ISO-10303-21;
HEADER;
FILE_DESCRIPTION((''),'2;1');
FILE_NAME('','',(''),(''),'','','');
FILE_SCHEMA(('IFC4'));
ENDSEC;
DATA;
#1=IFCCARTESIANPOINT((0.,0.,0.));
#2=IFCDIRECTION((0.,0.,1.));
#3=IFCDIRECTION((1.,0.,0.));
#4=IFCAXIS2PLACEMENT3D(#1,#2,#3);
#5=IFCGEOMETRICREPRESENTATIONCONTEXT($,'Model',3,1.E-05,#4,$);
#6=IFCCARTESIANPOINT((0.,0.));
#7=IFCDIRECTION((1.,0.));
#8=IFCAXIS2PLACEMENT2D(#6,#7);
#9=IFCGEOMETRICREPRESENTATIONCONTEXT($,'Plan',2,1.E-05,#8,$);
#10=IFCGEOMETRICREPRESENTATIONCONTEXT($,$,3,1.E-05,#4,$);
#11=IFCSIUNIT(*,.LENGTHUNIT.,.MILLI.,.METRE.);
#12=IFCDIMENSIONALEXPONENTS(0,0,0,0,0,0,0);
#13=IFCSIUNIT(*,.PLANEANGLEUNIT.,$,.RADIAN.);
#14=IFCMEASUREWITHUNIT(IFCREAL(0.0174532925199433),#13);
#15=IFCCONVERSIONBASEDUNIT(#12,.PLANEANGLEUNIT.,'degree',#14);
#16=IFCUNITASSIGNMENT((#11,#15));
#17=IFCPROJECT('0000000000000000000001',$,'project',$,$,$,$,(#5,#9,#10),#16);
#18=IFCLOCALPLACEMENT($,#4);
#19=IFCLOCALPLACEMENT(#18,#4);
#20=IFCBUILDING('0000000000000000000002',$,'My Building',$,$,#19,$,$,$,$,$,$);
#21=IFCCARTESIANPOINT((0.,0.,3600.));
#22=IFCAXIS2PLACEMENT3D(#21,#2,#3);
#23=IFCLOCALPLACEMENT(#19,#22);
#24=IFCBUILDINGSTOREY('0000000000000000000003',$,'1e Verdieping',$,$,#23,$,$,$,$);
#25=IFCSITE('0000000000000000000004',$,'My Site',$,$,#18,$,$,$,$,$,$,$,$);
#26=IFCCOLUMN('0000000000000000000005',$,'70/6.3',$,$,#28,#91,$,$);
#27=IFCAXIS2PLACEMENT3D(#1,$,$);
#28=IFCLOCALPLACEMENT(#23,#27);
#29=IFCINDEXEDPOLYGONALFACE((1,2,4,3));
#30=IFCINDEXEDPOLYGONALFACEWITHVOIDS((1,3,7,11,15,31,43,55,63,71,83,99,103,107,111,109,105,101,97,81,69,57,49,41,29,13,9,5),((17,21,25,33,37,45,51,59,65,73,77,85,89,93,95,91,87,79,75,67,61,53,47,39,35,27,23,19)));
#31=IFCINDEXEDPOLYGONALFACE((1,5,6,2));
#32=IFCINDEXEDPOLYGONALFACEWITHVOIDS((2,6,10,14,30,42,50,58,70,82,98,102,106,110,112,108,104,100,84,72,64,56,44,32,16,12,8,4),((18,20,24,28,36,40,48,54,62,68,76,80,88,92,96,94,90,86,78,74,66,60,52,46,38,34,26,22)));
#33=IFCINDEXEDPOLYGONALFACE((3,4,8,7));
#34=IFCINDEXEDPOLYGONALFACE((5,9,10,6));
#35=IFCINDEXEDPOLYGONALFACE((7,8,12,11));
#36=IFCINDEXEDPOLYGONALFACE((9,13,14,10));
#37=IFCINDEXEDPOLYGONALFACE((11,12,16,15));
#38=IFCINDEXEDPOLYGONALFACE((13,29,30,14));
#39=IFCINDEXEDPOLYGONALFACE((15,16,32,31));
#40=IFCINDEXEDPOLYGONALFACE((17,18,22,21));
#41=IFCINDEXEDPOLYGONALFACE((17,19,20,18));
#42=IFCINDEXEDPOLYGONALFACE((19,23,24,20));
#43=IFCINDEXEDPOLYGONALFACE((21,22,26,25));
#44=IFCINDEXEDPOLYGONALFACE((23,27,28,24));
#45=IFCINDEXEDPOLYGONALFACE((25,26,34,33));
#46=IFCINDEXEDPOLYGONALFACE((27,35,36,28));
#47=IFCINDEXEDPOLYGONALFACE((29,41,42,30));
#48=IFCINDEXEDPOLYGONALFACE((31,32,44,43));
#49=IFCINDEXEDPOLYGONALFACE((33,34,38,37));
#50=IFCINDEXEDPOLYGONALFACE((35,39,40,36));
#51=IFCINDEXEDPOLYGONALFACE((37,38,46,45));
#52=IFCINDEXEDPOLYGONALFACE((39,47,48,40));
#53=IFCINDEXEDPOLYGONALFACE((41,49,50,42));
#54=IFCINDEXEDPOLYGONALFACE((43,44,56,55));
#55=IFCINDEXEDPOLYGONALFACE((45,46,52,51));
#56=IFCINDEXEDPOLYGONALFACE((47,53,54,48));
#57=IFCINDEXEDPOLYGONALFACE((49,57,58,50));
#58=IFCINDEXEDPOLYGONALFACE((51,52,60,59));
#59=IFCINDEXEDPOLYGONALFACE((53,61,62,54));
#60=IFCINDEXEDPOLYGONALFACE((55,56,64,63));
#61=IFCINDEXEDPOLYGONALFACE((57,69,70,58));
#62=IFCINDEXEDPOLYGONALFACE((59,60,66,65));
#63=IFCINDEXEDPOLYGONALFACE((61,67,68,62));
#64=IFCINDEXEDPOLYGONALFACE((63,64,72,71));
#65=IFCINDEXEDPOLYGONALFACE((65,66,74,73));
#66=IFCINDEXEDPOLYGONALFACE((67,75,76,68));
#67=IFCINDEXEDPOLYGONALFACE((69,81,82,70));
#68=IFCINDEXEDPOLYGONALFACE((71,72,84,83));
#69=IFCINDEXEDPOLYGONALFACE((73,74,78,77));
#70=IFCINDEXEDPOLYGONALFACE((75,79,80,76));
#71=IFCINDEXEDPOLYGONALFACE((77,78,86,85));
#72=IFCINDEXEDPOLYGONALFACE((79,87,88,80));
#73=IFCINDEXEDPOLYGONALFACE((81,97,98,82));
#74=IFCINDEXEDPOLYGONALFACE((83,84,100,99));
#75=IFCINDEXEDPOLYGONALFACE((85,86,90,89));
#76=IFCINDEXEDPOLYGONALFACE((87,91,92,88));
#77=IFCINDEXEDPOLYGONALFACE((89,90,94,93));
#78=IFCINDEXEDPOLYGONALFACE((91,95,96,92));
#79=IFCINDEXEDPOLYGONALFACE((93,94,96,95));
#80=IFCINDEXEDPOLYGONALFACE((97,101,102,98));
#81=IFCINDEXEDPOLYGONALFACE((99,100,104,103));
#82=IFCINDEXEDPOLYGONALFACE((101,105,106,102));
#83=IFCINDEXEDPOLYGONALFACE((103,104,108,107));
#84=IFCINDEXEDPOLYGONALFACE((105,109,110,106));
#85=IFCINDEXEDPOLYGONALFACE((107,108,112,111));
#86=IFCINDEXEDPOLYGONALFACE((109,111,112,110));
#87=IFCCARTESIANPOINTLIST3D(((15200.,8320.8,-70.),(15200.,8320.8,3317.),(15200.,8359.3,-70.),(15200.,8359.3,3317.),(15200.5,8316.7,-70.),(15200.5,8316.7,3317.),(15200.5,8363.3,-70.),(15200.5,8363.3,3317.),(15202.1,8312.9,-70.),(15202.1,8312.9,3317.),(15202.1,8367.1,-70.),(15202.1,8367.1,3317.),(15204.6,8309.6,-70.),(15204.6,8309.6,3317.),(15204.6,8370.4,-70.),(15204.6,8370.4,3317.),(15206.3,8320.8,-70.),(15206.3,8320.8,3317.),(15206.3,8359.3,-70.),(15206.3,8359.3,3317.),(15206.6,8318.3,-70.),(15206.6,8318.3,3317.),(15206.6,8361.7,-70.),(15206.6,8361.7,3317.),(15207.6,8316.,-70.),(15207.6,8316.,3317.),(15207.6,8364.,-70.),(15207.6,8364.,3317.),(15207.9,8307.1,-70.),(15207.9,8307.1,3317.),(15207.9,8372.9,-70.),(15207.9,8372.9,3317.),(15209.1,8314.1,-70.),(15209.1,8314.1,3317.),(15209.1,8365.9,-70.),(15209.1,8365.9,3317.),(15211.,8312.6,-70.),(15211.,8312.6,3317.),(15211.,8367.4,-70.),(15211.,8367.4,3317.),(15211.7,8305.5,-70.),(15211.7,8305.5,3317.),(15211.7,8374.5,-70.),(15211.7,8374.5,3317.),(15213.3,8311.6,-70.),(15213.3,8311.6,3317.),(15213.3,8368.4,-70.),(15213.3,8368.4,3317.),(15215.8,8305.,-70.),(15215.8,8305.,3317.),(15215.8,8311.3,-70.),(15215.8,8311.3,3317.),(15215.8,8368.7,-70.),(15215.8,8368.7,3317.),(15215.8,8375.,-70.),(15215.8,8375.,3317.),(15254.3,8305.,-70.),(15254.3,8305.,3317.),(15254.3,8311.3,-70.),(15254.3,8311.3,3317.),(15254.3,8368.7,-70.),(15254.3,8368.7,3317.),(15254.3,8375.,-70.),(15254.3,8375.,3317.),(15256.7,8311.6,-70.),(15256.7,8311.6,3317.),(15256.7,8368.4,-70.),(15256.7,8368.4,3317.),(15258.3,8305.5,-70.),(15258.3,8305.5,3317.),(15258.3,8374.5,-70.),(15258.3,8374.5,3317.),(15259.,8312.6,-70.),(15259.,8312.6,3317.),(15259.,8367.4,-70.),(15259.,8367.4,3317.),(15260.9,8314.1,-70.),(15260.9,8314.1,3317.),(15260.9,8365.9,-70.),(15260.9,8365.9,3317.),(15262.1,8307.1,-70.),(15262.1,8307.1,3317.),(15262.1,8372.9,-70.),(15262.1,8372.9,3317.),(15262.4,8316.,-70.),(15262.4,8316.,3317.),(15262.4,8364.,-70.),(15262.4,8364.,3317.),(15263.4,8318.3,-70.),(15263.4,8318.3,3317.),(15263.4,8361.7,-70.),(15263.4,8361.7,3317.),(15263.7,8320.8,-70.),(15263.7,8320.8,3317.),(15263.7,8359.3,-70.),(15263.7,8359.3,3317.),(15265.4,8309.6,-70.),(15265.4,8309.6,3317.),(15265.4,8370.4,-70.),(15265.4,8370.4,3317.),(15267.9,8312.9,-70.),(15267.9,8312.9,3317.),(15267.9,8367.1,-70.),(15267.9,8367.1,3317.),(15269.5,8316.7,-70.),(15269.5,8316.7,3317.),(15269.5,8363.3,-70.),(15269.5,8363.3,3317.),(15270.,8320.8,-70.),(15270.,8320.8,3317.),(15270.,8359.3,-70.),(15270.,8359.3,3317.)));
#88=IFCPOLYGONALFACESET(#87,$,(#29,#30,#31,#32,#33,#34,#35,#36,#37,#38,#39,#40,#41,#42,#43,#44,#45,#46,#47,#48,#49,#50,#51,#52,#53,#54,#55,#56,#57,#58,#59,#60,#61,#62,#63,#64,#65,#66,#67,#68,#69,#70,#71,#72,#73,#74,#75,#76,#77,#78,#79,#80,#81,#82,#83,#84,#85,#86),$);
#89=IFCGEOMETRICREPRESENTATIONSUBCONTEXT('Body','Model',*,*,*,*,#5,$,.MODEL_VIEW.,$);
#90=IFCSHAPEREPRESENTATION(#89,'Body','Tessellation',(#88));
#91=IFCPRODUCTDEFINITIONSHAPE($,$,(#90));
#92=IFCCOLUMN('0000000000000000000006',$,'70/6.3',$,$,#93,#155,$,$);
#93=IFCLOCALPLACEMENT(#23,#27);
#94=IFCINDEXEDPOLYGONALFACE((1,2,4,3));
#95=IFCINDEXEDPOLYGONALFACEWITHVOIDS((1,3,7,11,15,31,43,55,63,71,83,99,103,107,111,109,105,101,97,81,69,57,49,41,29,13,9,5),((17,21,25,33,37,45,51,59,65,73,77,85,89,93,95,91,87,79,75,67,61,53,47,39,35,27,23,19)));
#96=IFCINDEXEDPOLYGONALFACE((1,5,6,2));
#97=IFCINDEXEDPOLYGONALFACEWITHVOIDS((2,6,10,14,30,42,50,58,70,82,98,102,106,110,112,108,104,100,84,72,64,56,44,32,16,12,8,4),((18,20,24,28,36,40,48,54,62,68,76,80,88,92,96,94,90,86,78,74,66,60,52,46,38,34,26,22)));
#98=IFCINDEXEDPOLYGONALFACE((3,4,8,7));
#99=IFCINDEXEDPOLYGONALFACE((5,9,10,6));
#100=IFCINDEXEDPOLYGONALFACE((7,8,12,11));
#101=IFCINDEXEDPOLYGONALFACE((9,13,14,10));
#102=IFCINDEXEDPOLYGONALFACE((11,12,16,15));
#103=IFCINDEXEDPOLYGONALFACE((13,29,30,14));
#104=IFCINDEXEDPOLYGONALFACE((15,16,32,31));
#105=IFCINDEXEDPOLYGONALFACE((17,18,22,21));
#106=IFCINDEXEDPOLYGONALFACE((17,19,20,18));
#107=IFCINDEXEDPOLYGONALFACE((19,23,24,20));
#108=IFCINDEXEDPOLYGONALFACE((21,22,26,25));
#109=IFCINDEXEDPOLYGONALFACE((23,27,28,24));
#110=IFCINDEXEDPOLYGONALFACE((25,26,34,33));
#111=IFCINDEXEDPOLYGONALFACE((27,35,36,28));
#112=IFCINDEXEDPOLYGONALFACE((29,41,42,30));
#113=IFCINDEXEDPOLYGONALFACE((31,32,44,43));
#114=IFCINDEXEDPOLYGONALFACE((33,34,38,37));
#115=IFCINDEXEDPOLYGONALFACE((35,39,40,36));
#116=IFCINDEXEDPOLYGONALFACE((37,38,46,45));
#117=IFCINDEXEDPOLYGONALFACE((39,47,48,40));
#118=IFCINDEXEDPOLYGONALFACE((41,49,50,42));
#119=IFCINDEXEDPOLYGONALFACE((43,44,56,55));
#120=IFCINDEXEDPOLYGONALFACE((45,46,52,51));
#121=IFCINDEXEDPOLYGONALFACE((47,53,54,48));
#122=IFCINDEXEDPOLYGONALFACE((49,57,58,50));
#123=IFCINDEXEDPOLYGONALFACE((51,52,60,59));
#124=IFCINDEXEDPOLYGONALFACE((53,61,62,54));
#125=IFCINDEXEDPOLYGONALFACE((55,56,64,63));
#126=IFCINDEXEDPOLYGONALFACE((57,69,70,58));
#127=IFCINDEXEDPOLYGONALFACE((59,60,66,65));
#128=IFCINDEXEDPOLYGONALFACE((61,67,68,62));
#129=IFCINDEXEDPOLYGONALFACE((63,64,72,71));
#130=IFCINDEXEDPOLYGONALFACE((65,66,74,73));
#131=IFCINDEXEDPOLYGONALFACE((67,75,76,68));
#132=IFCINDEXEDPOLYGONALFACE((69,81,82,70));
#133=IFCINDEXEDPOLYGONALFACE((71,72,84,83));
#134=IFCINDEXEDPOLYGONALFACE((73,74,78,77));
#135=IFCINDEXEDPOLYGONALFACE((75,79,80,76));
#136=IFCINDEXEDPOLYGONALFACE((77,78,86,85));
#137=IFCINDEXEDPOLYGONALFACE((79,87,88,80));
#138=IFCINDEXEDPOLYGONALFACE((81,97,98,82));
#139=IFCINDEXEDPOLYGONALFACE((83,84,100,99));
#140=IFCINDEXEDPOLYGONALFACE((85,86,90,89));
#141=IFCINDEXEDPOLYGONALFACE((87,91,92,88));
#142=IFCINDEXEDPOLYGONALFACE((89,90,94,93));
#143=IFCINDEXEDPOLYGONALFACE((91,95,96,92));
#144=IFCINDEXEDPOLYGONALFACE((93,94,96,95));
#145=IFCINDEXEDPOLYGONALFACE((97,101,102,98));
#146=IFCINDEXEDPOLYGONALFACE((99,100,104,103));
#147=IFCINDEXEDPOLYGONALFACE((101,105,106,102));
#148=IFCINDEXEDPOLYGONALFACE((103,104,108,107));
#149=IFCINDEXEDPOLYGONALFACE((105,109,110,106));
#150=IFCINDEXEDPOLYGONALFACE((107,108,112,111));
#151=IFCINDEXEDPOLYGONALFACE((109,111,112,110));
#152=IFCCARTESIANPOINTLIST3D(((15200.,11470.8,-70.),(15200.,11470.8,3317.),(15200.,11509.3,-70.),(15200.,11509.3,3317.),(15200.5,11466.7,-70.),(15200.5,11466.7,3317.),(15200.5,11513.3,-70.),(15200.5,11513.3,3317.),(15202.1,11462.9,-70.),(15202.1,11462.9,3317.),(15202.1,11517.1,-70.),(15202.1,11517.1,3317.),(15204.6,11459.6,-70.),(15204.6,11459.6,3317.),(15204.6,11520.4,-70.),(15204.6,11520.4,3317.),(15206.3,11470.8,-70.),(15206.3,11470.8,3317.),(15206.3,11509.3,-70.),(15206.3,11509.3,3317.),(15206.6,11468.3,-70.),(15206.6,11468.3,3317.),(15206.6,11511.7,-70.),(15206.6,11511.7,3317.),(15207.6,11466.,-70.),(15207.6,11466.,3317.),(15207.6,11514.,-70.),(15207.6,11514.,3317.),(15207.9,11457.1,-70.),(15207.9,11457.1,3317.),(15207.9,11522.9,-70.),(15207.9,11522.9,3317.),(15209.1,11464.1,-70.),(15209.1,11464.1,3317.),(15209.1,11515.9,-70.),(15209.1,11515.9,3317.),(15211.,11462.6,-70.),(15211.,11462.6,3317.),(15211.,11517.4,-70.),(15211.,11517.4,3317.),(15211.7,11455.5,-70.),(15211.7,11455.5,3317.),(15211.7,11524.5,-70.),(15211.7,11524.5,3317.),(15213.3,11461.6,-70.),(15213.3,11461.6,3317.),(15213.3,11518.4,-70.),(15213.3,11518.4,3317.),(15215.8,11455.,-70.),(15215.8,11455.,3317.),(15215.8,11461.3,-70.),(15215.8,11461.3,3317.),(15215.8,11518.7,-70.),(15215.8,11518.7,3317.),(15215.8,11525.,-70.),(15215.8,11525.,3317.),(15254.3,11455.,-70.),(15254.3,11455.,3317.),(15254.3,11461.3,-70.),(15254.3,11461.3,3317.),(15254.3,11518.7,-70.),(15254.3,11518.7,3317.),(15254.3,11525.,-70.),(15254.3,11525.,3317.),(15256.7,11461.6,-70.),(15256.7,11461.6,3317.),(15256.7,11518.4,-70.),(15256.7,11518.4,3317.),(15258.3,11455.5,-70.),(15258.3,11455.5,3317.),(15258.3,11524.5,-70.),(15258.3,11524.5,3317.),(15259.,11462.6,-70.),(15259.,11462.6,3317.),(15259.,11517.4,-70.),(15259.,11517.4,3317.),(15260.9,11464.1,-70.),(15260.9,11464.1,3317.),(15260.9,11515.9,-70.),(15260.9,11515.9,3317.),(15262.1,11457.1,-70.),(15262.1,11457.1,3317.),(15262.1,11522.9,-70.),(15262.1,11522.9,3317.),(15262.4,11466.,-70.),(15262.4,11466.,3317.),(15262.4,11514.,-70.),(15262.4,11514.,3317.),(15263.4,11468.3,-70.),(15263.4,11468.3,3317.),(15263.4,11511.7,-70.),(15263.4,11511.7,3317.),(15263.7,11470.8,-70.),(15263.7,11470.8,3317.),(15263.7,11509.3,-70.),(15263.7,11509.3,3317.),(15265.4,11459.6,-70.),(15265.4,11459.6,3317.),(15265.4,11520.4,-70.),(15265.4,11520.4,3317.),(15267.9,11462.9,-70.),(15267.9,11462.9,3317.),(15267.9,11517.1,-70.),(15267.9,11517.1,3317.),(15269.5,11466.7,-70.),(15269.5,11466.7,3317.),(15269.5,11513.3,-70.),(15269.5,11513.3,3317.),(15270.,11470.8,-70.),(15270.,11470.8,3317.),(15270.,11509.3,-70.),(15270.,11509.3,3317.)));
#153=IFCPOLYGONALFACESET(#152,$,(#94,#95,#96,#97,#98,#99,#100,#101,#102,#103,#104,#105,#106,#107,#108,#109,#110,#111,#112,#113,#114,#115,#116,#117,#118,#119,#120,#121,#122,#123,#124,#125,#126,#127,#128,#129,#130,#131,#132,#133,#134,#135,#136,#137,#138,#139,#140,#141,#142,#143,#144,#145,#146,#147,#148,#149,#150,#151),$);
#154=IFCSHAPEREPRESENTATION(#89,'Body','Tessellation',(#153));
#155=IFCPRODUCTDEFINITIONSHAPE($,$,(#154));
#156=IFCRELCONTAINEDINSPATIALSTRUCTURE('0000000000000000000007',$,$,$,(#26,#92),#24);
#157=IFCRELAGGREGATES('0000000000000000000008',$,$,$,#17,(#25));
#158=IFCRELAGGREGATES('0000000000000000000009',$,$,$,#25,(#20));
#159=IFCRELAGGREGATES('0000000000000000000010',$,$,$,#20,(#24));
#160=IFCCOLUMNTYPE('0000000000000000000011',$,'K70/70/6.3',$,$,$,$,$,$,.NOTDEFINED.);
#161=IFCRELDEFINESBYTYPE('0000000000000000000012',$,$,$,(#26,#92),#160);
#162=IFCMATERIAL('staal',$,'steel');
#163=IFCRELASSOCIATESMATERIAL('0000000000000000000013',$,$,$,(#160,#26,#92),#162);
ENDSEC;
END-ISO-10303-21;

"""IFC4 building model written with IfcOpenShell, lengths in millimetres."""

from ifc_helpers import new_model, entity, si_unit, converted_unit, frame, origin_with_axes, origin_2d_with_axis, place, context, subcontext, project, spatial, hollow_rectangle, extrude, material, material_profile, profile_set, profile_usage, type_object, element, save


model = new_model("IFC4")

# Units and contexts
model_context = context("Model", 3, precision=1e-05, world=origin_with_axes())
plan_context = context("Plan", 2, precision=1e-05, world=origin_2d_with_axis())
context_of_model = context(None, 3, precision=1e-05, world=origin_with_axes())
body_context = subcontext(model_context, "Body", "Model", "MODEL_VIEW")
ifc_project = project(units=[si_unit("LENGTHUNIT", "METRE", prefix="MILLI"), converted_unit("PLANEANGLEUNIT", "degree", entity("IfcReal", 0.0174532925199433), si_unit("PLANEANGLEUNIT", "RADIAN"), dimensions=[0, 0, 0, 0, 0, 0, 0])], contexts=[model_context, plan_context, context_of_model])

# Site, building, storey
site_placement = place(None, origin_with_axes())
site = spatial("IfcSite", under=ifc_project, at=site_placement, Name="My Site")
building_placement = place(site_placement, origin_with_axes())
building = spatial("IfcBuilding", under=site, at=building_placement, Name="My Building")
storey_placement = place(building_placement, frame((0.0, 0.0, 3600.0), z_axis=(0.0, 0.0, 1.0), x_axis=(1.0, 0.0, 0.0)))
storey = spatial("IfcBuildingStorey", under=building, at=storey_placement, Name="1e Verdieping")

# Columns
ifc_material_1 = material(Name="staal", Category="steel")
ifc_material_profile_1 = material_profile(ifc_material_1, hollow_rectangle(XDim=70.0, YDim=70.0, WallThickness=6.3, InnerFilletRadius=9.4, OuterFilletRadius=15.8))
ifc_profile_set_1 = profile_set([ifc_material_profile_1], Name="K70/70/6.3")
ifc_profile_usage_1 = profile_usage(ifc_profile_set_1)
column_type_1 = type_object("IfcColumnType", Name="K70/70/6.3", PredefinedType="NOTDEFINED", material=ifc_profile_set_1)
column_1_placement = place(storey_placement, frame((15235.0, 8340.0, -70.0), z_axis=(0.0, 0.0, 1.0), x_axis=(1.0, 0.0, 0.0)))
element("IfcColumn", 1, at=column_1_placement, inside=storey, type_object=column_type_1, material=ifc_profile_usage_1, Name="70/6.3", context=body_context, shape_type="SweptSolid", body=[
    extrude(hollow_rectangle(XDim=70.0, YDim=70.0, WallThickness=6.3, InnerFilletRadius=9.4, OuterFilletRadius=15.8), origin_with_axes(), (0.0, 0.0, 1.0), 3387.0),
])
ifc_profile_usage_2 = profile_usage(ifc_profile_set_1)
column_2_placement = place(storey_placement, frame((15235.0, 11490.0, -70.0), z_axis=(0.0, 0.0, 1.0), x_axis=(1.0, 0.0, 0.0)))
element("IfcColumn", 2, at=column_2_placement, inside=storey, type_object=column_type_1, material=ifc_profile_usage_2, Name="70/6.3", context=body_context, shape_type="SweptSolid", body=[
    extrude(hollow_rectangle(XDim=70.0, YDim=70.0, WallThickness=6.3, InnerFilletRadius=9.4, OuterFilletRadius=15.8), origin_with_axes(), (0.0, 0.0, 1.0), 3387.0),
])

save(model, "model.ifc")
